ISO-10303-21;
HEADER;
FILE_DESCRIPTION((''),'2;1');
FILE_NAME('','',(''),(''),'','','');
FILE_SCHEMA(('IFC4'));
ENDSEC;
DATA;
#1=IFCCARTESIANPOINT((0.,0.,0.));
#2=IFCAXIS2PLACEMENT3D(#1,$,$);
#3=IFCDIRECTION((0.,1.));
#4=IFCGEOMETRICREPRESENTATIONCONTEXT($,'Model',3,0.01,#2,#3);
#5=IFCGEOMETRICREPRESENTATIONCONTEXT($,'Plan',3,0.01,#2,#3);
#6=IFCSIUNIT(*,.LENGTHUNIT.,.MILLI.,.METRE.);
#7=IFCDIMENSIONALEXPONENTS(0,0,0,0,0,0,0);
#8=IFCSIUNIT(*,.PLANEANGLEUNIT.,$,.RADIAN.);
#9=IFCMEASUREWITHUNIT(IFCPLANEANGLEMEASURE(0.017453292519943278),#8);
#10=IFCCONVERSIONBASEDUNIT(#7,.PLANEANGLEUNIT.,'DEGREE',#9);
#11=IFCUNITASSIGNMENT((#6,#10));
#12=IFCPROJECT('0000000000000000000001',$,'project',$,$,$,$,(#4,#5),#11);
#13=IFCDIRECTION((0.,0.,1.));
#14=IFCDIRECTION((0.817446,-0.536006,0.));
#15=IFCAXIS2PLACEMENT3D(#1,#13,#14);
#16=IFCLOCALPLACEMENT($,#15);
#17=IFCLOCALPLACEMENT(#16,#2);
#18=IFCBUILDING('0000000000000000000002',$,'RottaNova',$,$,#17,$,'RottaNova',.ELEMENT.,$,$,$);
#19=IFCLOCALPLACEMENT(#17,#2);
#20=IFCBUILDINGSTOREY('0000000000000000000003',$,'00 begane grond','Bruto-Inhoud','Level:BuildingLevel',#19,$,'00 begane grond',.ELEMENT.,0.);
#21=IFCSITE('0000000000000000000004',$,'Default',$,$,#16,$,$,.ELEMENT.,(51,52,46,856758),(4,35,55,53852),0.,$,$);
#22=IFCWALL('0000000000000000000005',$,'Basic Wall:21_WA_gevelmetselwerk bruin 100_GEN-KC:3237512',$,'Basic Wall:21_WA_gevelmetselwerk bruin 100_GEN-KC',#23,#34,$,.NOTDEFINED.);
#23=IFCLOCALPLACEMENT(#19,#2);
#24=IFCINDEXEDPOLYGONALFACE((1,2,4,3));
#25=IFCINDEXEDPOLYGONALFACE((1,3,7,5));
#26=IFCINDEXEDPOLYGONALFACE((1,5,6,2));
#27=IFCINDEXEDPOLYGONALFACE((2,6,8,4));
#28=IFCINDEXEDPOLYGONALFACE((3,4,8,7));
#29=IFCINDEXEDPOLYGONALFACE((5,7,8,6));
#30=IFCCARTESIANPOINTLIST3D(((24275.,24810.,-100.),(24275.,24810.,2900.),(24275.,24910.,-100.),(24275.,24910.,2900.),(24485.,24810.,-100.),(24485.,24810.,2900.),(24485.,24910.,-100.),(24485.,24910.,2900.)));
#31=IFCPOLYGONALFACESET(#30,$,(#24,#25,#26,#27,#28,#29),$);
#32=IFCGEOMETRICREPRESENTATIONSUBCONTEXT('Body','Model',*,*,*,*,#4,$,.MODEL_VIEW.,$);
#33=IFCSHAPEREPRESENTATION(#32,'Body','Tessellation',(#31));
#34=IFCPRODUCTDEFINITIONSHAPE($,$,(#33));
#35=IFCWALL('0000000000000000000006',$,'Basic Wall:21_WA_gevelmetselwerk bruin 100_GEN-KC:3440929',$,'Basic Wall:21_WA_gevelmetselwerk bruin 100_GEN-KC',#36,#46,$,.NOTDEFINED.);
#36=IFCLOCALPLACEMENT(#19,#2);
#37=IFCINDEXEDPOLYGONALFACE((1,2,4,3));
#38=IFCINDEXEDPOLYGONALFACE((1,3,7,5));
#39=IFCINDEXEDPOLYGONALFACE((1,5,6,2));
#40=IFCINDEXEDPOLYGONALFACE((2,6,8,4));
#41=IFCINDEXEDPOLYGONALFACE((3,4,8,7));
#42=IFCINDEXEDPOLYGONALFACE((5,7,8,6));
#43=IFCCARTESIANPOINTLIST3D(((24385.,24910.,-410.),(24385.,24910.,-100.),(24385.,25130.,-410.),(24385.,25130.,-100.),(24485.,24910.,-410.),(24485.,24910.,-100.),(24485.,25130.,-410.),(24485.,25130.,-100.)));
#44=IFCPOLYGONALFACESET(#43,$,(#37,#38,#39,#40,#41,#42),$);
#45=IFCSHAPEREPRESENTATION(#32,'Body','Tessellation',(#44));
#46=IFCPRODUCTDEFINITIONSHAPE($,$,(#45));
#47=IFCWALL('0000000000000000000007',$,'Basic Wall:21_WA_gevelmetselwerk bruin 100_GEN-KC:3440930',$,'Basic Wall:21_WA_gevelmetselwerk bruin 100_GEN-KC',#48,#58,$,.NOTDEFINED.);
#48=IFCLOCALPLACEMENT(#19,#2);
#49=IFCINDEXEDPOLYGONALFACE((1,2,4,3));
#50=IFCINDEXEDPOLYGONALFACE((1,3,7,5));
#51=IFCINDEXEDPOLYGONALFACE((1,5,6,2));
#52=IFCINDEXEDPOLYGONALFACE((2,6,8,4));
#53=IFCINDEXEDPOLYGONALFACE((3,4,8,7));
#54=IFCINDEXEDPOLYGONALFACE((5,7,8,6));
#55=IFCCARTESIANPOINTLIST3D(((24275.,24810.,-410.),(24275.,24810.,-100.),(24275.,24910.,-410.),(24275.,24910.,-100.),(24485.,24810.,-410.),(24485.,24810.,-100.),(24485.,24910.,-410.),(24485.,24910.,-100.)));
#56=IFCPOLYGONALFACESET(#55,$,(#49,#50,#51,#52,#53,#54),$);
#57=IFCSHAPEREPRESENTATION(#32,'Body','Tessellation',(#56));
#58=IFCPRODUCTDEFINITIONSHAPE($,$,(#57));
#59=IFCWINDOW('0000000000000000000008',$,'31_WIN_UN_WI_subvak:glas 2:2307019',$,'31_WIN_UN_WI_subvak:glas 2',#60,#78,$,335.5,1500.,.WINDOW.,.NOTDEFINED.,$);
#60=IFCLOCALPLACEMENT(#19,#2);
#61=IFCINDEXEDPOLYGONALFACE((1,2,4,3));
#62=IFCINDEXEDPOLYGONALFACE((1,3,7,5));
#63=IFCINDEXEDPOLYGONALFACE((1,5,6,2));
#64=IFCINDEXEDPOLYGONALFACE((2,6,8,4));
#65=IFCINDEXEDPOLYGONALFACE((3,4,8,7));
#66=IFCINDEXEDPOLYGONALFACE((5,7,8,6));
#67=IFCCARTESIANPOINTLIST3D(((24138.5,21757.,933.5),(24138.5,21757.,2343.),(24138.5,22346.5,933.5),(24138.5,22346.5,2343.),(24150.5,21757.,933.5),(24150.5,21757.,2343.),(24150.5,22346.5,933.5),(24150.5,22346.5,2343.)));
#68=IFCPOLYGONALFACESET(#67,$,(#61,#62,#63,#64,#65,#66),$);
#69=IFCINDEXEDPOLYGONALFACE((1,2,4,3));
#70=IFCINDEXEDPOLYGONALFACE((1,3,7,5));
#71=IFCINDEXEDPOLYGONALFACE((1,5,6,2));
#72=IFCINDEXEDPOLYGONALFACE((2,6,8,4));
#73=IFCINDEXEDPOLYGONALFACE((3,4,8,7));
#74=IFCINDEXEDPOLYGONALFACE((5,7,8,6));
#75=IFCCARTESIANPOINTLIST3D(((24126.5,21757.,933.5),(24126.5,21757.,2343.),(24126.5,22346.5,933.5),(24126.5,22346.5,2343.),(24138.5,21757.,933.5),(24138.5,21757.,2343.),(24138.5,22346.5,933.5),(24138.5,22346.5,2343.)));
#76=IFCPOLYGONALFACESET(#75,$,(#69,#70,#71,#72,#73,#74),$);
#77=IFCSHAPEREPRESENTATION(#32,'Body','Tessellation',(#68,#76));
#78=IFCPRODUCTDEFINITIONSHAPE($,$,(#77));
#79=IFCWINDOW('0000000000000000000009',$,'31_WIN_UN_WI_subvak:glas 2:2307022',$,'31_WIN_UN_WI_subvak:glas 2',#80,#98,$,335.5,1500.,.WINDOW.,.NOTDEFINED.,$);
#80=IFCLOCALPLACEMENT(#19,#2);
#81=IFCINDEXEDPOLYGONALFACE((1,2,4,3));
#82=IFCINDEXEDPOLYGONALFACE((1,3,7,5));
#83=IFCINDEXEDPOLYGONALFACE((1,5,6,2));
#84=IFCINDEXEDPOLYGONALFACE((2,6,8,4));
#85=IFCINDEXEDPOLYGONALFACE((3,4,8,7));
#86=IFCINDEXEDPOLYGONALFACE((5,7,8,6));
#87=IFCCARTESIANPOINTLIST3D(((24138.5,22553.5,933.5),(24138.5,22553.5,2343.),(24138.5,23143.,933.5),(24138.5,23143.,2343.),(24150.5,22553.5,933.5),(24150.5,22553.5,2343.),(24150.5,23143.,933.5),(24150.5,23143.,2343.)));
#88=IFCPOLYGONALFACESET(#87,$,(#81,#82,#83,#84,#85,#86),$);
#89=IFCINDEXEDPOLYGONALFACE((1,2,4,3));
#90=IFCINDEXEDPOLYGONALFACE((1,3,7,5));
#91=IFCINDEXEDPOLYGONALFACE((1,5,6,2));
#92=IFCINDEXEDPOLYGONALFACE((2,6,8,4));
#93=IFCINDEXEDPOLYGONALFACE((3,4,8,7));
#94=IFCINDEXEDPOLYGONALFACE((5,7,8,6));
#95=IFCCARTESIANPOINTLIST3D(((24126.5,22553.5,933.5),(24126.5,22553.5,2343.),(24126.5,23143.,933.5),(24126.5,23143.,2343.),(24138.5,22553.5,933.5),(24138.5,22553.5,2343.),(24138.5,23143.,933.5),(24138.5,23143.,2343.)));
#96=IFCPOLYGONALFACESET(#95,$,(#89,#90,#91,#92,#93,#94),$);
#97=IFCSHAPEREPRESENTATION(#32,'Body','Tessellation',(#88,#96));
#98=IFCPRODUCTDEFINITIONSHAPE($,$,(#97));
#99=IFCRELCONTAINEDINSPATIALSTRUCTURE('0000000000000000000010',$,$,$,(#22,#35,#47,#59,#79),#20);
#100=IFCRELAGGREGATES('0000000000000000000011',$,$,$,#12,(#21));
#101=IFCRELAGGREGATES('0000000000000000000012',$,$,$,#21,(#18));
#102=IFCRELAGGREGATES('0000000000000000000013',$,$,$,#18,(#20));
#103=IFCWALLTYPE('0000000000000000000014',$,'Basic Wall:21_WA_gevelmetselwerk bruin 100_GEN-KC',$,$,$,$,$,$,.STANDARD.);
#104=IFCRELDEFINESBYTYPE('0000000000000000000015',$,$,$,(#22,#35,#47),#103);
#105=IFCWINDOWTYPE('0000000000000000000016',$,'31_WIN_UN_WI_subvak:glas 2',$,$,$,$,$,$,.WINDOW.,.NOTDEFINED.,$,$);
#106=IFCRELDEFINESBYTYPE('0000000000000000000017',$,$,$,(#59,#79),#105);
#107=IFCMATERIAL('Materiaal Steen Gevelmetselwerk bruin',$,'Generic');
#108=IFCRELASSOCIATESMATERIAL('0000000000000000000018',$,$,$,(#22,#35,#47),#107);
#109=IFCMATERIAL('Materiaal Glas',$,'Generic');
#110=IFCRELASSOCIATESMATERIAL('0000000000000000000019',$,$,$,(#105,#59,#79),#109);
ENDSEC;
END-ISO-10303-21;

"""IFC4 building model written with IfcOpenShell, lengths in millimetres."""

from ifc_helpers import new_model, entity, si_unit, converted_unit, direction, frame, origin, place, context, subcontext, project, spatial, indexed_curve, outline, extrude, source, transform, mapped, material, type_object, type_shapes, element, save


model = new_model("IFC4")

# Units and contexts
model_context = context("Model", 3, precision=0.01, world=origin(), true_north=direction((0.0, 1.0)))
plan_context = context("Plan", 3, precision=0.01, world=origin(), true_north=direction((0.0, 1.0)))
body_context = subcontext(model_context, "Body", "Model", "MODEL_VIEW")
ifc_project = project(units=[si_unit("LENGTHUNIT", "METRE", prefix="MILLI"), converted_unit("PLANEANGLEUNIT", "DEGREE", entity("IfcPlaneAngleMeasure", 0.017453292519943278), si_unit("PLANEANGLEUNIT", "RADIAN"), dimensions=[0, 0, 0, 0, 0, 0, 0])], contexts=[model_context, plan_context])

# Site, building, storey
site_placement = place(None, frame((0.0, 0.0, 0.0), z_axis=(0.0, 0.0, 1.0), x_axis=(0.817446, -0.536006, 0.0)))
site = spatial("IfcSite", under=ifc_project, at=site_placement, Name="Default", CompositionType="ELEMENT", RefLatitude=(51, 52, 46, 856758), RefLongitude=(4, 35, 55, 53852), RefElevation=0.0)
building_placement = place(site_placement, origin())
building = spatial("IfcBuilding", under=site, at=building_placement, Name="RottaNova", LongName="RottaNova", CompositionType="ELEMENT")
storey_placement = place(building_placement, origin())
storey = spatial("IfcBuildingStorey", under=building, at=storey_placement, Name="00 begane grond", Description="Bruto-Inhoud", ObjectType="Level:BuildingLevel", LongName="00 begane grond", CompositionType="ELEMENT", Elevation=0.0)

# Shared definitions
ifc_material_1 = material(Name="Materiaal Glas", Category="Generic")

# Walls
ifc_material_2 = material(Name="Materiaal Steen Gevelmetselwerk bruin", Category="Generic")
wall_type_1 = type_object("IfcWallType", Name="Basic Wall:21_WA_gevelmetselwerk bruin 100_GEN-KC", PredefinedType="STANDARD")
wall_1_placement = place(storey_placement, frame((24485.0, 24860.0, -100.0), z_axis=(0.0, 0.0, 1.0), x_axis=(-1.0, 0.0, 0.0)))
element("IfcWall", 1, at=wall_1_placement, inside=storey, type_object=wall_type_1, material=ifc_material_2, Name="Basic Wall:21_WA_gevelmetselwerk bruin 100_GEN-KC:3237512", ObjectType="Basic Wall:21_WA_gevelmetselwerk bruin 100_GEN-KC", PredefinedType="NOTDEFINED", context=body_context, shape_type="SweptSolid", body=[
    extrude(outline(indexed_curve([(210.0, 50.0), (0.0, 50.0), (0.0, -50.0), (210.0, -50.0), (210.0, 50.0)], self_intersect=False)), origin(), (0.0, 0.0, 1.0), 3000.0),
])
wall_2_placement = place(storey_placement, frame((24435.0, 25130.0, -410.0), z_axis=(0.0, 0.0, 1.0), x_axis=(0.0, -1.0, 0.0)))
element("IfcWall", 2, at=wall_2_placement, inside=storey, type_object=wall_type_1, material=ifc_material_2, Name="Basic Wall:21_WA_gevelmetselwerk bruin 100_GEN-KC:3440929", ObjectType="Basic Wall:21_WA_gevelmetselwerk bruin 100_GEN-KC", PredefinedType="NOTDEFINED", context=body_context, shape_type="SweptSolid", body=[
    extrude(outline(indexed_curve([(220.0, 50.0), (0.0, 50.0), (0.0, -50.0), (220.0, -50.0), (220.0, 50.0)], self_intersect=False)), origin(), (0.0, 0.0, 1.0), 310.0),
])
wall_3_placement = place(storey_placement, frame((24485.0, 24860.0, -410.0), z_axis=(0.0, 0.0, 1.0), x_axis=(-1.0, 0.0, 0.0)))
element("IfcWall", 3, at=wall_3_placement, inside=storey, type_object=wall_type_1, material=ifc_material_2, Name="Basic Wall:21_WA_gevelmetselwerk bruin 100_GEN-KC:3440930", ObjectType="Basic Wall:21_WA_gevelmetselwerk bruin 100_GEN-KC", PredefinedType="NOTDEFINED", context=body_context, shape_type="SweptSolid", body=[
    extrude(outline(indexed_curve([(210.0, 50.0), (0.0, 50.0), (0.0, -50.0), (210.0, -50.0), (210.0, 50.0)], self_intersect=False)), origin(), (0.0, 0.0, 1.0), 310.0),
])

# Windows
window_type = type_object("IfcWindowType", Name="31_WIN_UN_WI_subvak:glas 2", PartitioningType="NOTDEFINED", PredefinedType="WINDOW", material=ifc_material_1)
shared_shape_1 = source(origin(), body_context, "Body", "SweptSolid", [
    extrude(outline(indexed_curve([(-294.7, -6.0), (294.7, -6.0), (294.7, 6.0), (-294.7, 6.0), (-294.7, -6.0)], self_intersect=False)), frame((0.0, -6.0, 0.0)), (0.0, 0.0, 1.0), 1409.5),
    extrude(outline(indexed_curve([(-294.8, -6.0), (294.8, -6.0), (294.8, 6.0), (-294.8, 6.0), (-294.8, -6.0)], self_intersect=False)), frame((0.0, 6.0, 0.0)), (0.0, 0.0, 1.0), 1409.5),
])
type_shapes(window_type, [shared_shape_1])
for number, where, z_axis, x_axis, name in (
    (4, (24138.5, 22051.7, 933.5), (0.0, 0.0, 1.0), (0.0, 1.0, 0.0), "31_WIN_UN_WI_subvak:glas 2:2307019"),
    (5, (24138.5, 22848.2, 933.5), (0.0, 0.0, 1.0), (0.0, 1.0, 0.0), "31_WIN_UN_WI_subvak:glas 2:2307022"),
):
    element("IfcWindow", number, at=place(storey_placement, frame(where, z_axis=z_axis, x_axis=x_axis)), inside=storey, type_object=window_type, material=ifc_material_1, Name=name, ObjectType="31_WIN_UN_WI_subvak:glas 2", OverallHeight=335.5, OverallWidth=1500.0, PartitioningType="NOTDEFINED", PredefinedType="WINDOW", context=body_context, shape_type="MappedRepresentation", body=[
        mapped(shared_shape_1, transform((0.0, 0.0, 0.0), scale=1.0)),
    ])

save(model, "model.ifc")
